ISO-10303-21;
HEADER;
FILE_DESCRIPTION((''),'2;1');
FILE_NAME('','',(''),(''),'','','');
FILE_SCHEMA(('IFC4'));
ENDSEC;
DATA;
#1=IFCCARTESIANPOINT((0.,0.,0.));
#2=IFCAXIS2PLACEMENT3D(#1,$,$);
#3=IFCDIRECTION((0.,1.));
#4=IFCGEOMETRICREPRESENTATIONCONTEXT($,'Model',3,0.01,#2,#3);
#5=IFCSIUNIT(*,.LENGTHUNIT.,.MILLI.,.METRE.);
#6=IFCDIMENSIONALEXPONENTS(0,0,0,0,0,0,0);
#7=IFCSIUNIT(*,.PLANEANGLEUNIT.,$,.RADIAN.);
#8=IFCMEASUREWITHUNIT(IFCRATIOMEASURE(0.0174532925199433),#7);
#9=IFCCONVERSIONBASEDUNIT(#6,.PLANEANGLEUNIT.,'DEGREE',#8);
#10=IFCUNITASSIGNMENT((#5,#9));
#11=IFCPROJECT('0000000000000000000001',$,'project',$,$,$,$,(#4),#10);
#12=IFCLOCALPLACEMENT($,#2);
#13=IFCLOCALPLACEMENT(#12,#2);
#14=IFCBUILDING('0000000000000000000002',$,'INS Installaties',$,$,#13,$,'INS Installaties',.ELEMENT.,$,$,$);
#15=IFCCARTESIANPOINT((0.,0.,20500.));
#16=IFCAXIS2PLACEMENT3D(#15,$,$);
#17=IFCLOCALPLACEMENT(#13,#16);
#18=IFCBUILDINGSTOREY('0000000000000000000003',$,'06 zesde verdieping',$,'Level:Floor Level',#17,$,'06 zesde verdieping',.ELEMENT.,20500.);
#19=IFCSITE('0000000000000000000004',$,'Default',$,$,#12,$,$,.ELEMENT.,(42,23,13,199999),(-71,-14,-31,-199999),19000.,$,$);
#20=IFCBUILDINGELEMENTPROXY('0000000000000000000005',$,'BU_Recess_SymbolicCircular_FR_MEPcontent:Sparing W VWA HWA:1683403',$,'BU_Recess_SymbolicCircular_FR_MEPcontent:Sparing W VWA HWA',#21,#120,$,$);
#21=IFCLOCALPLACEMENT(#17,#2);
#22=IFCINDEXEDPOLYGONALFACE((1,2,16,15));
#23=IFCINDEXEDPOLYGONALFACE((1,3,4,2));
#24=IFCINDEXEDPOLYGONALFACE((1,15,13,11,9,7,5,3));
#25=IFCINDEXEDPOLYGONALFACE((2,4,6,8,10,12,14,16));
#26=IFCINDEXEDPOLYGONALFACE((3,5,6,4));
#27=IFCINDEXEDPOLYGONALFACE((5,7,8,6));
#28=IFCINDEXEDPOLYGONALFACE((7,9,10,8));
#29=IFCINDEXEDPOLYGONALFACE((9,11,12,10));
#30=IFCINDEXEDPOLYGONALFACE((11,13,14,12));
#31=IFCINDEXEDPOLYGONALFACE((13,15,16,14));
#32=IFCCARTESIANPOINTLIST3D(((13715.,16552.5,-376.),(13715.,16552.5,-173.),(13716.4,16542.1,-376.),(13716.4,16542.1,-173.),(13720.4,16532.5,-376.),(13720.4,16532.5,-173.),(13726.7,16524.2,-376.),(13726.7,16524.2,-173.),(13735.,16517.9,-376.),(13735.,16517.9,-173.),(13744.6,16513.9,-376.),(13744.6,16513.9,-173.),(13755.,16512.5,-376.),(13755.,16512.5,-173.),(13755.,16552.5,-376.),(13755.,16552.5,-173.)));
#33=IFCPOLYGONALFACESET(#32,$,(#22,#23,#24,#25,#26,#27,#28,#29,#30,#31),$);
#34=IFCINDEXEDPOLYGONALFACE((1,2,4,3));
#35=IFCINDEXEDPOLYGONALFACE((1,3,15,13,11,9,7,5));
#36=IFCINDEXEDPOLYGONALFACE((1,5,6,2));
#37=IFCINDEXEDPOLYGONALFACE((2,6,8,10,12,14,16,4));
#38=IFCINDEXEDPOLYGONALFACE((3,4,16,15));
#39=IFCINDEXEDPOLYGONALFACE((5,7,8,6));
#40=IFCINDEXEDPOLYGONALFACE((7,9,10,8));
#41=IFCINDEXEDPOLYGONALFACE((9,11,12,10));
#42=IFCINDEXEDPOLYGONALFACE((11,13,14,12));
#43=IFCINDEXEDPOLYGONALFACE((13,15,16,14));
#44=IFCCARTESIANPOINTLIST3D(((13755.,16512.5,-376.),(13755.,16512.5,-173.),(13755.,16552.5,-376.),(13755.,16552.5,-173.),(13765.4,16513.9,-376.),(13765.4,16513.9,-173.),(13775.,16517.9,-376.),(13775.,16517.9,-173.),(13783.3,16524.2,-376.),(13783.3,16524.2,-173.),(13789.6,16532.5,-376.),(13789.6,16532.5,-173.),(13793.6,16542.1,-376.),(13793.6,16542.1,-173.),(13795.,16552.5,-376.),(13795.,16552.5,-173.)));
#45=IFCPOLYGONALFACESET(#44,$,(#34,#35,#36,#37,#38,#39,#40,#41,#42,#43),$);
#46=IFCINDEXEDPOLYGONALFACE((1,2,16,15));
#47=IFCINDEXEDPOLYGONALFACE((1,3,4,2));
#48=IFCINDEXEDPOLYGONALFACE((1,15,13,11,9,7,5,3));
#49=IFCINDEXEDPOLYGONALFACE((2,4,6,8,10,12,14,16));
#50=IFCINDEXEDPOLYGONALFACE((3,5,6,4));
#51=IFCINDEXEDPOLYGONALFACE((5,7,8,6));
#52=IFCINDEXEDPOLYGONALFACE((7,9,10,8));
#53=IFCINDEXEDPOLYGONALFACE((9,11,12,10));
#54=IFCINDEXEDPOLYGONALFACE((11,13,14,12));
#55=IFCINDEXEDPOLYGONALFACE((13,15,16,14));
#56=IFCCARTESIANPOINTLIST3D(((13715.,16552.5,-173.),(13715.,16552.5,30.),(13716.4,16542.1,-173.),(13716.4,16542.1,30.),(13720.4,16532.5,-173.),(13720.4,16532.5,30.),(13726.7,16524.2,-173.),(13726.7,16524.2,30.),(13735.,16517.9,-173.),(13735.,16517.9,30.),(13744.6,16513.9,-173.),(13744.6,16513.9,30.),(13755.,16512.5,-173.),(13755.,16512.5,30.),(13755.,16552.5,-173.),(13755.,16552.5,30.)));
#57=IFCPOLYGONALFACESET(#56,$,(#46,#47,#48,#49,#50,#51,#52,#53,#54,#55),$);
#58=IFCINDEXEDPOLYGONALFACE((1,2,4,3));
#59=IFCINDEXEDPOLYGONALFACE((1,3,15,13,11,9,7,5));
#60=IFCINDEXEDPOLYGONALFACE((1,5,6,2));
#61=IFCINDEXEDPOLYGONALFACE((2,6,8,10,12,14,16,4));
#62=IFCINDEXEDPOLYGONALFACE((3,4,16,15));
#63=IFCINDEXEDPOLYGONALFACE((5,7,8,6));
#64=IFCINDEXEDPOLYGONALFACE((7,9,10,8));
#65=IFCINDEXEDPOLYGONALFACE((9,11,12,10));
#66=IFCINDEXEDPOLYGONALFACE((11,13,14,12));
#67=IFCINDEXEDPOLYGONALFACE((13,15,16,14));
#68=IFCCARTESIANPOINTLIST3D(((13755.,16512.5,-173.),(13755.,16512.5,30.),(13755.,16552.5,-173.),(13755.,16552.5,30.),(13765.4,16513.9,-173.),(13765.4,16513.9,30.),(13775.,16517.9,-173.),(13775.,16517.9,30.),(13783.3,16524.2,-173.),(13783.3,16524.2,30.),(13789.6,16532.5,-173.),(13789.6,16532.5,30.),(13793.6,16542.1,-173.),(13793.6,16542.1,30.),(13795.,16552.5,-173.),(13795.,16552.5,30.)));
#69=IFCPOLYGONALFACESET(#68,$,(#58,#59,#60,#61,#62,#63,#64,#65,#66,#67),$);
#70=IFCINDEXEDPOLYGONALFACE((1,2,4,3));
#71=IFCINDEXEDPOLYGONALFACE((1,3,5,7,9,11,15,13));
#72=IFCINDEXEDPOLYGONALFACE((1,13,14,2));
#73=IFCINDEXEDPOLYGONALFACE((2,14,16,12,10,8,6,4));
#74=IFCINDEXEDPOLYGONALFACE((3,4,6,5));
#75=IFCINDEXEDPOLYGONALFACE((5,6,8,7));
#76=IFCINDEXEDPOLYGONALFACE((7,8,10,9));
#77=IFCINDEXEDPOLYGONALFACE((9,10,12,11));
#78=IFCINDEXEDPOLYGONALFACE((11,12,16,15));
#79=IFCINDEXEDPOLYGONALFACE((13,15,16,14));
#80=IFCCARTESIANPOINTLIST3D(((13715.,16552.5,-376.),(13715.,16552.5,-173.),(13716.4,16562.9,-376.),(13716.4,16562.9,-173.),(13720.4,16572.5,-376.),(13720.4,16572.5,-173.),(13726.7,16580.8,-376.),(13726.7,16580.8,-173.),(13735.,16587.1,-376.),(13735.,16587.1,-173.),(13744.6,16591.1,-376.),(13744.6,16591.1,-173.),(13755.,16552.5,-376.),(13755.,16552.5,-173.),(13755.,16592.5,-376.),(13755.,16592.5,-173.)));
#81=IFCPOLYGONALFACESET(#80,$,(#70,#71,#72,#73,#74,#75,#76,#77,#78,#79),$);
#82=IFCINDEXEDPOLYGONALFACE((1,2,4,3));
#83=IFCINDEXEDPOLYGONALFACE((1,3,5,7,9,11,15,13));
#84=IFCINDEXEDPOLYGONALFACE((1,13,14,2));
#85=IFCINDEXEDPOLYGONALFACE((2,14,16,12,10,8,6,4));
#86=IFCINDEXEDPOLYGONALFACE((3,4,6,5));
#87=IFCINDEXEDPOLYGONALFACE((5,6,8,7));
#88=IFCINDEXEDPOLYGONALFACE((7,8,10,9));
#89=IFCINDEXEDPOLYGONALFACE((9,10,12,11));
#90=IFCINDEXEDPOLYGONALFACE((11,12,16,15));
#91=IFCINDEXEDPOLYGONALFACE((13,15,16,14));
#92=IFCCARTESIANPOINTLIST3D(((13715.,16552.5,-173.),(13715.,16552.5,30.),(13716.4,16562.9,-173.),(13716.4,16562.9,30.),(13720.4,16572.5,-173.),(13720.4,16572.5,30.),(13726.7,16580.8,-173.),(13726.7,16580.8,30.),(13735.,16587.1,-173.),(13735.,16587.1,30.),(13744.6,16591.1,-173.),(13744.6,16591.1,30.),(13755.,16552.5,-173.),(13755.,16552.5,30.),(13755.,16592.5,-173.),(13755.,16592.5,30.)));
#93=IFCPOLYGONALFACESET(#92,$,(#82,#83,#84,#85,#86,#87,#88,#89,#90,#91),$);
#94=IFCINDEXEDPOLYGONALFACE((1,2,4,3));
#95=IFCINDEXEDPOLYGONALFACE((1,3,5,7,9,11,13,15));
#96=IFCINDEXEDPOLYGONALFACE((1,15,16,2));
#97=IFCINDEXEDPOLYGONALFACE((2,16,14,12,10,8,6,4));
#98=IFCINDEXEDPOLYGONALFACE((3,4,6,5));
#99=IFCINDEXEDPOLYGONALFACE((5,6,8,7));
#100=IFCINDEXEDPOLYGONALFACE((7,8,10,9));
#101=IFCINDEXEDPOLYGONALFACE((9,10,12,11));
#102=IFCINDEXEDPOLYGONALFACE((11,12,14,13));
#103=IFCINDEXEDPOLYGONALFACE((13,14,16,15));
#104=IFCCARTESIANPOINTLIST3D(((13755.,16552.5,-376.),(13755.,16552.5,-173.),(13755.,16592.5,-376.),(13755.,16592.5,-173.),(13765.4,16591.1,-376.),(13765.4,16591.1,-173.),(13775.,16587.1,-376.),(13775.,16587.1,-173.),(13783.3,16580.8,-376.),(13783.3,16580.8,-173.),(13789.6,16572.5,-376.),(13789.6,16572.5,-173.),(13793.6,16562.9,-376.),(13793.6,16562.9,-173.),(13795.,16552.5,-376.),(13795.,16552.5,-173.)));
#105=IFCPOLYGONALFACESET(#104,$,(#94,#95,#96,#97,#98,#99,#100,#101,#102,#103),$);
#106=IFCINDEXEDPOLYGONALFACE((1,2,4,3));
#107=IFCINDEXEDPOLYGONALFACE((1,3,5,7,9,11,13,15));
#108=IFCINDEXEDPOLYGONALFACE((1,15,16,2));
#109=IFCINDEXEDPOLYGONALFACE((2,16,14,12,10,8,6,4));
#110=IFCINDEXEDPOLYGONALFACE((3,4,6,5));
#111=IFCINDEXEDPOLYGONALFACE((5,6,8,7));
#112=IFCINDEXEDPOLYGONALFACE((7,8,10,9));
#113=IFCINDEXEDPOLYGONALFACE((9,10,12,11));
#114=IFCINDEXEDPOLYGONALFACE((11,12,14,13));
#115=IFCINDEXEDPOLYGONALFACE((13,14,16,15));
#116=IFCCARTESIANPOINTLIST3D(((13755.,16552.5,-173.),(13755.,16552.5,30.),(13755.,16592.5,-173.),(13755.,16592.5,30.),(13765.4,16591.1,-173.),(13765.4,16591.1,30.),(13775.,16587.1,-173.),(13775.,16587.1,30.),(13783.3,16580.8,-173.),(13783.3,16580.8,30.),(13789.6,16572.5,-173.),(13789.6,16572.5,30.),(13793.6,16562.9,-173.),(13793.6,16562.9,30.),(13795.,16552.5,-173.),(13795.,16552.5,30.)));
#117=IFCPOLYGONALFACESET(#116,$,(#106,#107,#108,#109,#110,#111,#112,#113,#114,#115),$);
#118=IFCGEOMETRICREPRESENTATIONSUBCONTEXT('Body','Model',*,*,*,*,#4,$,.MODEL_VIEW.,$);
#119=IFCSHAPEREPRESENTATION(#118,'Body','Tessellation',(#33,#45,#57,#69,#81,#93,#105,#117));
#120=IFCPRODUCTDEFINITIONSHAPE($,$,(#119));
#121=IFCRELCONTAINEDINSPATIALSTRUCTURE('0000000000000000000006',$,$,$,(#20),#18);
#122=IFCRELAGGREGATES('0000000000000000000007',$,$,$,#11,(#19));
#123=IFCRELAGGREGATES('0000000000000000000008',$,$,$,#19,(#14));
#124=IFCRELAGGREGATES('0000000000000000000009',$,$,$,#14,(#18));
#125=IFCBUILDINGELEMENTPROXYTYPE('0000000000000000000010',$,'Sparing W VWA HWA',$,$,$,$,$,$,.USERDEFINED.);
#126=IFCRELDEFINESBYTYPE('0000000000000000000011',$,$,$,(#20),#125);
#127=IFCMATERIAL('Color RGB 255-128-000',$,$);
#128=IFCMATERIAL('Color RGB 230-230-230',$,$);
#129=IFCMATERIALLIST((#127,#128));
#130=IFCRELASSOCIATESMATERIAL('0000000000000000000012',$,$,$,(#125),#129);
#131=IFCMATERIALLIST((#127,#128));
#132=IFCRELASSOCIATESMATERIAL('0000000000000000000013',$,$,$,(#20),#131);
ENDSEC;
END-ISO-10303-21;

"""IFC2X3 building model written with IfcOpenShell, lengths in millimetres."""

from ifc_helpers import new_model, entity, si_unit, converted_unit, direction, frame, frame_2d, origin, place, context, subcontext, project, spatial, polyline, circle_curve, parameter, trimmed, segment, composite_curve, outline, extrude, source, transform, mapped, material, material_list, type_object, type_shapes, element, save


model = new_model("IFC2X3")

# Units and contexts
model_context = context("Model", 3, precision=0.01, world=origin(), true_north=direction((0.0, 1.0)))
body_context = subcontext(model_context, "Body", "Model", "MODEL_VIEW")
ifc_project = project(units=[si_unit("LENGTHUNIT", "METRE", prefix="MILLI"), converted_unit("PLANEANGLEUNIT", "DEGREE", entity("IfcRatioMeasure", 0.0174532925199433), si_unit("PLANEANGLEUNIT", "RADIAN"), dimensions=[0, 0, 0, 0, 0, 0, 0])], contexts=[model_context])

# Site, building, storey
site_placement = place(None, origin())
site = spatial("IfcSite", under=ifc_project, at=site_placement, Name="Default", CompositionType="ELEMENT", RefLatitude=(42, 23, 13, 199999), RefLongitude=(-71, -14, -31, -199999), RefElevation=19000.0)
building_placement = place(site_placement, origin())
building = spatial("IfcBuilding", under=site, at=building_placement, Name="INS Installaties", LongName="INS Installaties", CompositionType="ELEMENT")
storey_placement = place(building_placement, frame((0.0, 0.0, 20500.0)))
storey = spatial("IfcBuildingStorey", under=building, at=storey_placement, Name="06 zesde verdieping", ObjectType="Level:Floor Level", LongName="06 zesde verdieping", CompositionType="ELEMENT", Elevation=20500.0)

# Building element proxy
ifc_material_1 = material(Name="Color RGB 255-128-000")
ifc_material_2 = material(Name="Color RGB 230-230-230")
ifc_material_list_1 = material_list([ifc_material_1, ifc_material_2])
building_element_proxy_type_1 = type_object("IfcBuildingElementProxyType", Name="Sparing W VWA HWA", PredefinedType="USERDEFINED", material=ifc_material_list_1)
shared_shape_1 = source(origin(), body_context, "Body", "SweptSolid", [
    extrude(outline(composite_curve([segment(trimmed(circle_curve(frame_2d((13.3, 13.3), x_axis=(1.0, 0.0)), 40.0), [parameter(180.0)], [parameter(270.0)], True, "PARAMETER"), True, "CONTINUOUS"), segment(polyline([(13.3, -26.7), (13.3, 13.3)]), True, "CONTINUOUS"), segment(polyline([(13.3, 13.3), (-26.7, 13.3)]), True, "CONTINUOUS")], self_intersect=False)), frame((13.3, 13.3, -403.0), z_axis=(0.0, 0.0, 1.0), x_axis=(-1.0, 0.0, 0.0)), (0.0, 0.0, 1.0), 203.0),
    extrude(outline(composite_curve([segment(polyline([(-26.7, -13.3), (13.3, -13.3)]), True, "CONTINUOUS"), segment(polyline([(13.3, -13.3), (13.3, 26.7)]), True, "CONTINUOUS"), segment(trimmed(circle_curve(frame_2d((13.3, -13.3), x_axis=(1.0, 0.0)), 40.0), [parameter(90.0)], [parameter(180.0)], True, "PARAMETER"), True, "CONTINUOUS")], self_intersect=False)), frame((-13.3, 13.3, -403.0)), (0.0, 0.0, 1.0), 203.0),
    extrude(outline(composite_curve([segment(trimmed(circle_curve(frame_2d((13.3, 13.3), x_axis=(1.0, 0.0)), 40.0), [parameter(180.0)], [parameter(270.0)], True, "PARAMETER"), True, "CONTINUOUS"), segment(polyline([(13.3, -26.7), (13.3, 13.3)]), True, "CONTINUOUS"), segment(polyline([(13.3, 13.3), (-26.7, 13.3)]), True, "CONTINUOUS")], self_intersect=False)), frame((13.3, 13.3, -200.0), z_axis=(0.0, 0.0, 1.0), x_axis=(-1.0, 0.0, 0.0)), (0.0, 0.0, 1.0), 203.0),
    extrude(outline(composite_curve([segment(polyline([(-26.7, -13.3), (13.3, -13.3)]), True, "CONTINUOUS"), segment(polyline([(13.3, -13.3), (13.3, 26.7)]), True, "CONTINUOUS"), segment(trimmed(circle_curve(frame_2d((13.3, -13.3), x_axis=(1.0, 0.0)), 40.0), [parameter(90.0)], [parameter(180.0)], True, "PARAMETER"), True, "CONTINUOUS")], self_intersect=False)), frame((-13.3, 13.3, -200.0)), (0.0, 0.0, 1.0), 203.0),
    extrude(outline(composite_curve([segment(polyline([(-26.7, -13.3), (13.3, -13.3)]), True, "CONTINUOUS"), segment(polyline([(13.3, -13.3), (13.3, 26.7)]), True, "CONTINUOUS"), segment(trimmed(circle_curve(frame_2d((13.3, -13.3), x_axis=(1.0, 0.0)), 40.0), [parameter(90.0)], [parameter(180.0)], True, "PARAMETER"), True, "CONTINUOUS")], self_intersect=False)), frame((13.3, -13.3, -403.0), z_axis=(0.0, 0.0, 1.0), x_axis=(-1.0, 0.0, 0.0)), (0.0, 0.0, 1.0), 203.0),
    extrude(outline(composite_curve([segment(polyline([(-26.7, -13.3), (13.3, -13.3)]), True, "CONTINUOUS"), segment(polyline([(13.3, -13.3), (13.3, 26.7)]), True, "CONTINUOUS"), segment(trimmed(circle_curve(frame_2d((13.3, -13.3), x_axis=(1.0, 0.0)), 40.0), [parameter(90.0)], [parameter(180.0)], True, "PARAMETER"), True, "CONTINUOUS")], self_intersect=False)), frame((13.3, -13.3, -200.0), z_axis=(0.0, 0.0, 1.0), x_axis=(-1.0, 0.0, 0.0)), (0.0, 0.0, 1.0), 203.0),
    extrude(outline(composite_curve([segment(trimmed(circle_curve(frame_2d((13.3, 13.3), x_axis=(1.0, 0.0)), 40.0), [parameter(180.0)], [parameter(270.0)], True, "PARAMETER"), True, "CONTINUOUS"), segment(polyline([(13.3, -26.7), (13.3, 13.3)]), True, "CONTINUOUS"), segment(polyline([(13.3, 13.3), (-26.7, 13.3)]), True, "CONTINUOUS")], self_intersect=False)), frame((-13.3, -13.3, -403.0)), (0.0, 0.0, 1.0), 203.0),
    extrude(outline(composite_curve([segment(trimmed(circle_curve(frame_2d((13.3, 13.3), x_axis=(1.0, 0.0)), 40.0), [parameter(180.0)], [parameter(270.0)], True, "PARAMETER"), True, "CONTINUOUS"), segment(polyline([(13.3, -26.7), (13.3, 13.3)]), True, "CONTINUOUS"), segment(polyline([(13.3, 13.3), (-26.7, 13.3)]), True, "CONTINUOUS")], self_intersect=False)), frame((-13.3, -13.3, -200.0)), (0.0, 0.0, 1.0), 203.0),
])
type_shapes(building_element_proxy_type_1, [shared_shape_1])
ifc_material_list_2 = material_list([ifc_material_1, ifc_material_2])
proxy_1_placement = place(storey_placement, frame((13755.0, 16552.5, 27.0), z_axis=(0.0, 0.0, 1.0), x_axis=(-1.0, 0.0, 0.0)))
element("IfcBuildingElementProxy", 1, at=proxy_1_placement, inside=storey, type_object=building_element_proxy_type_1, material=ifc_material_list_2, Name="BU_Recess_SymbolicCircular_FR_MEPcontent:Sparing W VWA HWA:1683403", ObjectType="BU_Recess_SymbolicCircular_FR_MEPcontent:Sparing W VWA HWA", context=body_context, shape_type="MappedRepresentation", body=[
    mapped(shared_shape_1, transform((0.0, 0.0, 0.0), scale=1.0)),
])

save(model, "model.ifc")
